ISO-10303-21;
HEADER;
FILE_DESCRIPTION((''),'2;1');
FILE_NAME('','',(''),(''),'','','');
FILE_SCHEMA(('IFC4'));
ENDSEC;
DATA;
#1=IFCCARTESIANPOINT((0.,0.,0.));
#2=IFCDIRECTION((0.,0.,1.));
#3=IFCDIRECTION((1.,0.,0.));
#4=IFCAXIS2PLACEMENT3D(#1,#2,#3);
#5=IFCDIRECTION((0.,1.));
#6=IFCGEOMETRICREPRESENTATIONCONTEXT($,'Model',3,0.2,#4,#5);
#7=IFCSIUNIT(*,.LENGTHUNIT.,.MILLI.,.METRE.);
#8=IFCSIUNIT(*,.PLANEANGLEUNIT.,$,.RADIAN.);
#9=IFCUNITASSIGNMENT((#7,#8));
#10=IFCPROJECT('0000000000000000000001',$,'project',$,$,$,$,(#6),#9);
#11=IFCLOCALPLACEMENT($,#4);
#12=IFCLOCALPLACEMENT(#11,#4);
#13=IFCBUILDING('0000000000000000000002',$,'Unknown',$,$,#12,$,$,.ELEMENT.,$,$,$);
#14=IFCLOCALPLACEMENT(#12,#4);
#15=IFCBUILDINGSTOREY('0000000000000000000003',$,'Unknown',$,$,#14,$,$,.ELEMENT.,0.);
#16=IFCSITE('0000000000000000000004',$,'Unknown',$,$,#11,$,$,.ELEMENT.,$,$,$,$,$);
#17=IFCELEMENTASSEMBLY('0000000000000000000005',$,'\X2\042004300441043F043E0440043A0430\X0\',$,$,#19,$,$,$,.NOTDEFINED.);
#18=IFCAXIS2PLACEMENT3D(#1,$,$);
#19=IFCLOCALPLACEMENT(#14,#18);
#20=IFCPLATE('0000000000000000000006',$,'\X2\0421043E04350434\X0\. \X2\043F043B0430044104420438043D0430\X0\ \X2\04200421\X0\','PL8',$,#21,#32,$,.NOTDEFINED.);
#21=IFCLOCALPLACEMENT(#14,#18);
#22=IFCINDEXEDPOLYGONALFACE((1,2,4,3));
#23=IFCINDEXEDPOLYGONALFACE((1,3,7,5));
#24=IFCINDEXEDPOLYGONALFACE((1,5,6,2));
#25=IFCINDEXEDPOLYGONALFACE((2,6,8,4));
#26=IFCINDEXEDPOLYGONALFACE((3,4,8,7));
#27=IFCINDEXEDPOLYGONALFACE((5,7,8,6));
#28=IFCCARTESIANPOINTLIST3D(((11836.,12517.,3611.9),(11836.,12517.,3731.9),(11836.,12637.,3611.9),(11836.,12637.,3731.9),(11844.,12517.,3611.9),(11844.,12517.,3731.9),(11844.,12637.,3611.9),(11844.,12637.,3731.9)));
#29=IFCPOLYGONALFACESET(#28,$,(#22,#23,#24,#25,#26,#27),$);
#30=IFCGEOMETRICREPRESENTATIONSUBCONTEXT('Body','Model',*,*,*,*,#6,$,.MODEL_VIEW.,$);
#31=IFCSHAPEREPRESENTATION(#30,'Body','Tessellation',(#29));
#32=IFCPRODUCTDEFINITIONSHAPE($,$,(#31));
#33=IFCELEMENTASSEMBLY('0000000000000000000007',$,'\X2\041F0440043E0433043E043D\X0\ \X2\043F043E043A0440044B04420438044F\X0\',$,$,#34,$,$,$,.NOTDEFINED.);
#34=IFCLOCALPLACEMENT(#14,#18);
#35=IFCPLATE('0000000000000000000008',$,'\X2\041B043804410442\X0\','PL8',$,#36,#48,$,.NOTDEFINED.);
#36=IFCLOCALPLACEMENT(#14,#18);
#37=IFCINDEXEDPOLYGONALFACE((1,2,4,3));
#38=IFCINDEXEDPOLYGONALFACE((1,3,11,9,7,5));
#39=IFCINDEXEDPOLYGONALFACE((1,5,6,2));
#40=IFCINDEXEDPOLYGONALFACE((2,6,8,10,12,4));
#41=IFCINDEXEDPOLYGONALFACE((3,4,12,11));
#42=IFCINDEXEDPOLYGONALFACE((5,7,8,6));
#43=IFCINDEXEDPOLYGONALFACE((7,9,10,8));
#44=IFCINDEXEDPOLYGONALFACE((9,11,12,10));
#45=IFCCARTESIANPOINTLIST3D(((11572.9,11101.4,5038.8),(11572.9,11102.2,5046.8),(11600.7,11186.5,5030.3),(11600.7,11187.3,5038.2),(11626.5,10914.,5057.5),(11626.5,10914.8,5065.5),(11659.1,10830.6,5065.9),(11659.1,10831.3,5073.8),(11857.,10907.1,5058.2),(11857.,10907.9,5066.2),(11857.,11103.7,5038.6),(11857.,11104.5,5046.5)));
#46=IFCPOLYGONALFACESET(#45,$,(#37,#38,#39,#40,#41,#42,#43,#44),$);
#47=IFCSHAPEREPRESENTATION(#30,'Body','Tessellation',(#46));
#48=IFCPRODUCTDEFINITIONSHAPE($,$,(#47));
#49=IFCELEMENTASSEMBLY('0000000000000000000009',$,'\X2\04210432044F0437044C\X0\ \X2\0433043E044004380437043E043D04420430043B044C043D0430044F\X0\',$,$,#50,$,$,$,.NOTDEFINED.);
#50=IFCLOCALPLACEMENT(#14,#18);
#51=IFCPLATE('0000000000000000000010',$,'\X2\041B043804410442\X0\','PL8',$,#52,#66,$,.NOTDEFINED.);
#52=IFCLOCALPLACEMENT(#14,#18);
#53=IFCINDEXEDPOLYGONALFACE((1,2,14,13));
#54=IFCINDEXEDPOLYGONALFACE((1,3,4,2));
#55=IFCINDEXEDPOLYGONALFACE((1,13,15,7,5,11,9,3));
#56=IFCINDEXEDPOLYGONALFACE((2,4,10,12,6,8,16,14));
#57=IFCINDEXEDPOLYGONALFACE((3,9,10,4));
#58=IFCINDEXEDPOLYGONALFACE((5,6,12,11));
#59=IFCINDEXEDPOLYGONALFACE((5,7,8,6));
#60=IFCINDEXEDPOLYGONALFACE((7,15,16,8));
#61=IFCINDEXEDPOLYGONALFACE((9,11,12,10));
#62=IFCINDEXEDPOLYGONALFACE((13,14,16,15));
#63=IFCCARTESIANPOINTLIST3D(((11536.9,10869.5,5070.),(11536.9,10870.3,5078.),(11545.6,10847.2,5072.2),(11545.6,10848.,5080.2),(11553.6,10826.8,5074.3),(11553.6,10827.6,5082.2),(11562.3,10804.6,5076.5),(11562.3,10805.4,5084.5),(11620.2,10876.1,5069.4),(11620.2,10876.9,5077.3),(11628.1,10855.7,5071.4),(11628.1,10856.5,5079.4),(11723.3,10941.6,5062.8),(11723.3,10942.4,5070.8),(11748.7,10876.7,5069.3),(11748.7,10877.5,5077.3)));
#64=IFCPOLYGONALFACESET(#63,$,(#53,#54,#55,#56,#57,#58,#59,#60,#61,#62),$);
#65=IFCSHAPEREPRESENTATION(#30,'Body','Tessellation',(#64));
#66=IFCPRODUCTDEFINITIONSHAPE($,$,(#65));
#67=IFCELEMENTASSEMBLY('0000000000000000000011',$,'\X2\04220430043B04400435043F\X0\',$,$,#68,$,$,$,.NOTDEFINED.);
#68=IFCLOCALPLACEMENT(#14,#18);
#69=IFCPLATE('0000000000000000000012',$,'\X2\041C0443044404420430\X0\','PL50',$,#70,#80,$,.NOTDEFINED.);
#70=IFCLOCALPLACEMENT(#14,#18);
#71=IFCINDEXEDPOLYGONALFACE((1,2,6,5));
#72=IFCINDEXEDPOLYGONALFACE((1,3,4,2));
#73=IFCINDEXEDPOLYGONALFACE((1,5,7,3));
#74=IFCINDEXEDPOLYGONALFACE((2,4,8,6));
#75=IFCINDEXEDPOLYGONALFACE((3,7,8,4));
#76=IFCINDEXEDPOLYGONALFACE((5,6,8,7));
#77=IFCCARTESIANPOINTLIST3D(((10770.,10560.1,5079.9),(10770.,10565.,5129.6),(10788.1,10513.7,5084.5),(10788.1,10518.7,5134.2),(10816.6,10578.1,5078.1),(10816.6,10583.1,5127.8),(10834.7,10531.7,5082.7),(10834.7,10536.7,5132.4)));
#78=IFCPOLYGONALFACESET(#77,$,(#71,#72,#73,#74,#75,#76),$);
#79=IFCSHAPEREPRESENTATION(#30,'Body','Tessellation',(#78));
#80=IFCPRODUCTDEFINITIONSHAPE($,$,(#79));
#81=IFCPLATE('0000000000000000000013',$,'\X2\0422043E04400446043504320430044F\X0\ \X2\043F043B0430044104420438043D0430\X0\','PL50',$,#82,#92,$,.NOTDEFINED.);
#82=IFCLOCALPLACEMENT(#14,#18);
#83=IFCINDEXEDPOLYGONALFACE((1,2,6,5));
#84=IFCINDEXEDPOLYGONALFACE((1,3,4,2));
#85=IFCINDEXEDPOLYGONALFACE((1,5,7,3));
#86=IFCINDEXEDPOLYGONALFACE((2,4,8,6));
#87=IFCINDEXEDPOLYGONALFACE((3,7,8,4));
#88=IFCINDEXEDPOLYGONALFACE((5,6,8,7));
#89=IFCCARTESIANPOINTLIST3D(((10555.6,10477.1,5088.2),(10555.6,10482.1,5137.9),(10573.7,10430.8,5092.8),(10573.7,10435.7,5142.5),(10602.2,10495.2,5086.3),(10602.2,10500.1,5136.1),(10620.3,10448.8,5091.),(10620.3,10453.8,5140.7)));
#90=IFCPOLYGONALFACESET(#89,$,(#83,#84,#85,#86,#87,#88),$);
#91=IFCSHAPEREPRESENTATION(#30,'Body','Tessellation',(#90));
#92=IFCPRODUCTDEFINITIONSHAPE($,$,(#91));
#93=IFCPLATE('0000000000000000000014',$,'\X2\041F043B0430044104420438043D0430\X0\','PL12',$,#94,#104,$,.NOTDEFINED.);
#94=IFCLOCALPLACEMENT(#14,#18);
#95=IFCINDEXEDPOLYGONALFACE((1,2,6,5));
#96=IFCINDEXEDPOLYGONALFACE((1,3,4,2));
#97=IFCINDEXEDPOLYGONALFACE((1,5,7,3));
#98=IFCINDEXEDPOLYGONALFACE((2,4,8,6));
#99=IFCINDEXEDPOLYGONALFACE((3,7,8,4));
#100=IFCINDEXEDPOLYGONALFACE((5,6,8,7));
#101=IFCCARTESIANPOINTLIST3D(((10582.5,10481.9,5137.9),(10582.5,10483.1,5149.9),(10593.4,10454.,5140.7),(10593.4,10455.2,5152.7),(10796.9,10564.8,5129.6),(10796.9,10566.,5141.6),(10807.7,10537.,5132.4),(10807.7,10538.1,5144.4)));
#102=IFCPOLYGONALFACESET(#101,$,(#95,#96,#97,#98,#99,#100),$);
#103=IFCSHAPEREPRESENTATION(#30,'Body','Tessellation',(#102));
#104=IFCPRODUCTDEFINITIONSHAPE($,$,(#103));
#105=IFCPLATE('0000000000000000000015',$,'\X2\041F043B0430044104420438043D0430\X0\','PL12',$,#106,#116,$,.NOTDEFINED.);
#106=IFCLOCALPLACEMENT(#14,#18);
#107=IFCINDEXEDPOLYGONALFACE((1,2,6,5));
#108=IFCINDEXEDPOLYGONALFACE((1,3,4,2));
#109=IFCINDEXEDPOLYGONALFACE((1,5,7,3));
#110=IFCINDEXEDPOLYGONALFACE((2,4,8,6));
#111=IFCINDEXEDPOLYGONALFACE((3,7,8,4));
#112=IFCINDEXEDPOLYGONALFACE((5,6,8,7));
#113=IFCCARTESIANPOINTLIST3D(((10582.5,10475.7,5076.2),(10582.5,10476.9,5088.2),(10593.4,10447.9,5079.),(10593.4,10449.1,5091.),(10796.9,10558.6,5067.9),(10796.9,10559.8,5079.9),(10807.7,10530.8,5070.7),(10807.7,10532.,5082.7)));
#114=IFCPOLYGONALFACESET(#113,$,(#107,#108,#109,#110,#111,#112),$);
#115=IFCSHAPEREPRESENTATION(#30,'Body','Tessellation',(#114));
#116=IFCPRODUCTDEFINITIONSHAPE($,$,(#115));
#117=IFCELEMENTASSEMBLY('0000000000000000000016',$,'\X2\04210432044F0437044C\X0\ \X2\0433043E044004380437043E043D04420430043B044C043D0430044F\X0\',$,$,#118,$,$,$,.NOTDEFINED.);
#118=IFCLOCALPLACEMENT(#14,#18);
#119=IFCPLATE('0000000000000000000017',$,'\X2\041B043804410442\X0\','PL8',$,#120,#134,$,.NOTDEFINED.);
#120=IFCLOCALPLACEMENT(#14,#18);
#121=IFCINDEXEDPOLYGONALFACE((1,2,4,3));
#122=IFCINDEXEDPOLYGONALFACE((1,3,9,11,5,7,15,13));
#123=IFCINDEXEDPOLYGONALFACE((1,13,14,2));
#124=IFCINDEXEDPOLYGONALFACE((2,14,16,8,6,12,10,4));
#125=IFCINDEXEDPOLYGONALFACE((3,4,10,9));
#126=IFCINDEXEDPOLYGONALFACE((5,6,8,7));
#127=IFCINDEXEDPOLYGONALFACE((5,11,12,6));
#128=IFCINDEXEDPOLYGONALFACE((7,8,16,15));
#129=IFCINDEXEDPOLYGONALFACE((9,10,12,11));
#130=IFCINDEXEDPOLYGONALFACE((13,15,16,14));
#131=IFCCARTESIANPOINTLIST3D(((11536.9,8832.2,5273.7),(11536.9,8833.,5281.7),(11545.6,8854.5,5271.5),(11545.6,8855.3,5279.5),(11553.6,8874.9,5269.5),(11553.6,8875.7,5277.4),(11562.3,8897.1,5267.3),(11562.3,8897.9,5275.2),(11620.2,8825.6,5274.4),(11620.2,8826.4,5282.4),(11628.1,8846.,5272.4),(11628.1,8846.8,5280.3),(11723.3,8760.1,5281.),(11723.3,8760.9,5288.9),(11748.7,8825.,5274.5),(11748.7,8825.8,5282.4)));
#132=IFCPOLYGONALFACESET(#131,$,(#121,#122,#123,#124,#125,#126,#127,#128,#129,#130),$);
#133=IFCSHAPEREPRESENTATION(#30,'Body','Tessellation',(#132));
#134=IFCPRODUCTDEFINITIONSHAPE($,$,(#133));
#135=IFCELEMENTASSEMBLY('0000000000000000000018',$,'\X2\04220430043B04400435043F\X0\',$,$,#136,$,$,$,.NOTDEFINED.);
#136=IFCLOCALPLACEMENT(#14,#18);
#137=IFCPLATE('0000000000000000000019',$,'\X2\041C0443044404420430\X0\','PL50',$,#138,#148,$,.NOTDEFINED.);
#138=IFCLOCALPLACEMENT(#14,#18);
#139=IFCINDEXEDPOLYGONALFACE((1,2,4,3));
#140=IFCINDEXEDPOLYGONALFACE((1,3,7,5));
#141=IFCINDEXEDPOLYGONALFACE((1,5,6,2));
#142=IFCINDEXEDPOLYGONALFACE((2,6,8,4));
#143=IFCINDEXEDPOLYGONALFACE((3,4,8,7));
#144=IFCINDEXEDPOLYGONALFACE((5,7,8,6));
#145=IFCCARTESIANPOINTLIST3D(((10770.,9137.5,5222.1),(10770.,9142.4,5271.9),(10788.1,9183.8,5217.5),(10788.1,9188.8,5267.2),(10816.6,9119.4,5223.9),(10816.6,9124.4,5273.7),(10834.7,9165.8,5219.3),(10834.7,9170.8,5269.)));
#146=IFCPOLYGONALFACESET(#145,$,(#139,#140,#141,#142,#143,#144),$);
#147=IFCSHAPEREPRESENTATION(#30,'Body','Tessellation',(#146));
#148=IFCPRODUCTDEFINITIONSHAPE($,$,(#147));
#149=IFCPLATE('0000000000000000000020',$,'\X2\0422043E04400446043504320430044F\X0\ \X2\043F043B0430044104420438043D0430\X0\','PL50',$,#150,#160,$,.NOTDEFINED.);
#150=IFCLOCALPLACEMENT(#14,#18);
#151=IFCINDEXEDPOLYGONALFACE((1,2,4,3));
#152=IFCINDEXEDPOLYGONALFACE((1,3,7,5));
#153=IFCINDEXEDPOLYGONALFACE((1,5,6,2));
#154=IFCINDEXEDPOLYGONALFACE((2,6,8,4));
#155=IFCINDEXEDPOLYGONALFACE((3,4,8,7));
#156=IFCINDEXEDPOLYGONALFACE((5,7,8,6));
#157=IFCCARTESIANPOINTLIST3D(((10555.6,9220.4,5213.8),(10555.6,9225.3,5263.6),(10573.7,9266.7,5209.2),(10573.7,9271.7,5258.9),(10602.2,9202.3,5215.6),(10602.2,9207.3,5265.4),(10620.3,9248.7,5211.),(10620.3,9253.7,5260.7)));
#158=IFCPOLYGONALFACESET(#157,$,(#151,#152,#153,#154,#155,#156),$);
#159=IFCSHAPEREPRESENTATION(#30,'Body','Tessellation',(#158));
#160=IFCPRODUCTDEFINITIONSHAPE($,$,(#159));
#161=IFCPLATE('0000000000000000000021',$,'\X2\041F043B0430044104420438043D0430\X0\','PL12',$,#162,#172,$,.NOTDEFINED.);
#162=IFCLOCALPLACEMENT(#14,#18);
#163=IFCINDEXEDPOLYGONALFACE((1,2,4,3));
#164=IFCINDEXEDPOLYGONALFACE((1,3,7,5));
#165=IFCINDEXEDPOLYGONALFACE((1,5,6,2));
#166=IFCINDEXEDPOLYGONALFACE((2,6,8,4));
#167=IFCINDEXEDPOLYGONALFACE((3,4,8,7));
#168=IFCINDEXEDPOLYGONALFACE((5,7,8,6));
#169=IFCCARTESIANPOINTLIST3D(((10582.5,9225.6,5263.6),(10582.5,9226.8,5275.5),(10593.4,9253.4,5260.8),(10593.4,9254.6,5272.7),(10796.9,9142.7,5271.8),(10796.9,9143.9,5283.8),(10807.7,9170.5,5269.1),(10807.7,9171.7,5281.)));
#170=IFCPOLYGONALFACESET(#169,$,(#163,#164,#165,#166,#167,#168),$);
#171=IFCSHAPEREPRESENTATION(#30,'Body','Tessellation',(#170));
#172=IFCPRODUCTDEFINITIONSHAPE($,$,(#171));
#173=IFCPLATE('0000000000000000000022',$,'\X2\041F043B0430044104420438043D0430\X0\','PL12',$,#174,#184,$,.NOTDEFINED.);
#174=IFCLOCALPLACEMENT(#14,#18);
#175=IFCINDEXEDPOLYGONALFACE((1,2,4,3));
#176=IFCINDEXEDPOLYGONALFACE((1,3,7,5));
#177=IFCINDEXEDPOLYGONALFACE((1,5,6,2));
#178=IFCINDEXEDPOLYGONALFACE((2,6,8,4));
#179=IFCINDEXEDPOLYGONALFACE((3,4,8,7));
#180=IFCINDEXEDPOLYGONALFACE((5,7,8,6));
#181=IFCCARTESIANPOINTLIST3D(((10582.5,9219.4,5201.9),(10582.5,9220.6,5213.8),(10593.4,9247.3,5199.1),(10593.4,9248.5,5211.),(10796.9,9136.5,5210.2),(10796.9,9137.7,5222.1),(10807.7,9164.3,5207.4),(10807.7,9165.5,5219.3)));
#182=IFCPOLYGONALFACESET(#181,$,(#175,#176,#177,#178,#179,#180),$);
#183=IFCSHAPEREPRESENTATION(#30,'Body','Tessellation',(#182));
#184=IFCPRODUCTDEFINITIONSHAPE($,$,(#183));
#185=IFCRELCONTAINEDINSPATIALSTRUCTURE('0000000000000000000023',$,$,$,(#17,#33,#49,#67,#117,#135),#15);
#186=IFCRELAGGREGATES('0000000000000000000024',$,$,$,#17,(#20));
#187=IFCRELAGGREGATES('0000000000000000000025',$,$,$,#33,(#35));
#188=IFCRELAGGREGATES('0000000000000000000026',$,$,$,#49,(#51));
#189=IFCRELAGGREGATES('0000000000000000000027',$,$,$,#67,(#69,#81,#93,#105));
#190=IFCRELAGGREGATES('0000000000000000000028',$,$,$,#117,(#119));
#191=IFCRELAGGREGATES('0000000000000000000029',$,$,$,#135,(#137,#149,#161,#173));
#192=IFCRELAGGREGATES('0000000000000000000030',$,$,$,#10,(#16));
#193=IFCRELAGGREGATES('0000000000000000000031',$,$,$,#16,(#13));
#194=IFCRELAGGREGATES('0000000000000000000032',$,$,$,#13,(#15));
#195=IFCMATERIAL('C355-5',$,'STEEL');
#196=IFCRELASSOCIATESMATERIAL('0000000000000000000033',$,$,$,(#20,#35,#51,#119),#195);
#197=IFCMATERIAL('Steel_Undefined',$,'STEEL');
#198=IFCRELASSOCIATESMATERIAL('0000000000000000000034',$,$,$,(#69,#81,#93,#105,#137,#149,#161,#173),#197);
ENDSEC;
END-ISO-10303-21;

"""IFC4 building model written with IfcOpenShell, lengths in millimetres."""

from ifc_helpers import new_model, si_unit, direction, frame, origin_with_axes, place, context, subcontext, project, spatial, line, indexed_curve, outline, extrude, material, element, aggregate, save


model = new_model("IFC4")

# Units and contexts
model_context = context("Model", 3, precision=0.2, world=origin_with_axes(), true_north=direction((0.0, 1.0)))
body_context = subcontext(model_context, "Body", "Model", "MODEL_VIEW")
ifc_project = project(units=[si_unit("LENGTHUNIT", "METRE", prefix="MILLI"), si_unit("PLANEANGLEUNIT", "RADIAN")], contexts=[model_context])

# Site, building, storey
site_placement = place(None, origin_with_axes())
site = spatial("IfcSite", under=ifc_project, at=site_placement, Name="Unknown", CompositionType="ELEMENT")
building_placement = place(site_placement, origin_with_axes())
building = spatial("IfcBuilding", under=site, at=building_placement, Name="Unknown", CompositionType="ELEMENT")
storey_placement = place(building_placement, origin_with_axes())
storey = spatial("IfcBuildingStorey", under=building, at=storey_placement, Name="Unknown", CompositionType="ELEMENT", Elevation=0.0)

# Element assemblies, plates
assembly_1_placement = place(storey_placement, frame((6000.0, 12577.0, 3671.9), z_axis=(0.0, -1.0, 0.0), x_axis=(1.0, 0.0, 0.0)))
assembly_1 = element("IfcElementAssembly", 1, at=assembly_1_placement, inside=storey, Name="Распорка", PredefinedType="NOTDEFINED")
ifc_material_1 = material(Name="C355-5", Category="STEEL")
plate_1_placement = place(assembly_1_placement, frame((5840.0, 60.0, -60.0), z_axis=(1.0, 0.0, 0.0), x_axis=(0.0, 0.0, 1.0)))
plate_1 = element("IfcPlate", 2, at=plate_1_placement, material=ifc_material_1, Name="Соед. пластина РС", Description="PL8", PredefinedType="NOTDEFINED", context=body_context, shape_type="SolidModel", body=[
    extrude(outline(indexed_curve([(0.0, 0.0), (120.0, 0.0), (120.0, 120.0), (0.0, 120.0)], segments=[line(1, 2, 3, 4, 1)])), frame((0.0, 0.0, 4.0), z_axis=(0.0, 0.0, 1.0), x_axis=(1.0, 0.0, 0.0)), (0.0, 0.0, -1.0), 8.0),
])
aggregate(assembly_1, [plate_1])
assembly_2_placement = place(storey_placement, frame((12000.0, 11010.8, 5051.9), z_axis=(0.0, -0.995037, 0.099504), x_axis=(-1.0, 0.0, 0.0)))
assembly_2 = element("IfcElementAssembly", 3, at=assembly_2_placement, inside=storey, Name="Прогон покрытия", PredefinedType="NOTDEFINED")
plate_2_placement = place(assembly_2_placement, frame((373.5, 0.0, 96.9), z_axis=(0.0, -1.0, 0.0), x_axis=(-0.362317, 0.0, 0.932055)))
plate_2 = element("IfcPlate", 4, at=plate_2_placement, material=ifc_material_1, Name="Лист", Description="PL8", PredefinedType="NOTDEFINED", context=body_context, shape_type="SolidModel", body=[
    extrude(outline(indexed_curve([(0.0, 0.0), (90.0, 0.0), (90.0, 212.3), (-94.2, 283.9), (-264.6, 75.2), (-194.9, 18.3)], segments=[line(1, 2, 3, 4, 5, 6, 1)])), frame((0.0, 0.0, 4.0), z_axis=(0.0, 0.0, 1.0), x_axis=(1.0, 0.0, 0.0)), (0.0, 0.0, -1.0), 8.0),
])
aggregate(assembly_2, [plate_2])
assembly_3_placement = place(storey_placement, frame((10695.1, 10506.9, 5110.3), z_axis=(0.362317, -0.927429, 0.092743), x_axis=(0.932055, 0.360519, -0.036052)))
assembly_3 = element("IfcElementAssembly", 5, at=assembly_3_placement, inside=storey, Name="Связь горизонтальная", PredefinedType="NOTDEFINED")
plate_3_placement = place(assembly_3_placement, frame((916.8, 0.0, -35.0), z_axis=(0.0, -1.0, 0.0), x_axis=(1.0, 0.0, 0.0)))
plate_3 = element("IfcPlate", 6, at=plate_3_placement, material=ifc_material_1, Name="Лист", Description="PL8", PredefinedType="NOTDEFINED", context=body_context, shape_type="SolidModel", body=[
    extrude(outline(indexed_curve([(0.0, 0.0), (200.0, 0.0), (200.0, 70.0), (0.0, 70.0), (0.0, 46.0), (80.0, 46.0), (80.0, 24.0), (0.0, 24.0)], segments=[line(1, 2, 3, 4, 5, 6, 7, 8, 1)])), frame((0.0, 0.0, 4.0), z_axis=(0.0, 0.0, 1.0), x_axis=(1.0, 0.0, 0.0)), (0.0, 0.0, -1.0), 8.0),
])
aggregate(assembly_3, [plate_3])

# Element assembly, plates
assembly_4_placement = place(storey_placement, frame((10811.4, 10527.7, 5133.3), z_axis=(-0.932055, -0.360519, 0.036052), x_axis=(-0.362317, 0.927429, -0.092743)))
assembly_4 = element("IfcElementAssembly", 7, at=assembly_4_placement, inside=storey, Name="Талреп", PredefinedType="NOTDEFINED")
ifc_material_2 = material(Name="Steel_Undefined", Category="STEEL")
plate_4_placement = place(assembly_4_placement, origin_with_axes())
plate_4 = element("IfcPlate", 8, at=plate_4_placement, material=ifc_material_2, Name="Муфта", Description="PL50", PredefinedType="NOTDEFINED", context=body_context, shape_type="SolidModel", body=[
    extrude(outline(indexed_curve([(0.0, 0.0), (50.0, 0.0), (50.0, 50.0), (0.0, 50.0)], segments=[line(1, 2, 3, 4, 1)])), frame((0.0, 0.0, 25.0), z_axis=(0.0, 0.0, 1.0), x_axis=(1.0, 0.0, 0.0)), (0.0, 0.0, -1.0), 50.0),
])
plate_5_placement = place(assembly_4_placement, frame((0.0, 0.0, 230.0), z_axis=(0.0, 0.0, 1.0), x_axis=(1.0, 0.0, 0.0)))
plate_5 = element("IfcPlate", 9, at=plate_5_placement, material=ifc_material_2, Name="Торцевая пластина", Description="PL50", PredefinedType="NOTDEFINED", context=body_context, shape_type="SolidModel", body=[
    extrude(outline(indexed_curve([(0.0, 0.0), (50.0, 0.0), (50.0, 50.0), (0.0, 50.0)], segments=[line(1, 2, 3, 4, 1)])), frame((0.0, 0.0, 25.0), z_axis=(0.0, 0.0, 1.0), x_axis=(1.0, 0.0, 0.0)), (0.0, 0.0, -1.0), 50.0),
])
plate_6_placement = place(assembly_4_placement, frame((10.0, -6.0, 230.0), z_axis=(0.0, 1.0, 0.0), x_axis=(1.0, 0.0, 0.0)))
plate_6 = element("IfcPlate", 10, at=plate_6_placement, material=ifc_material_2, Name="Пластина", Description="PL12", PredefinedType="NOTDEFINED", context=body_context, shape_type="SolidModel", body=[
    extrude(outline(indexed_curve([(0.0, 0.0), (30.0, 0.0), (30.0, 230.0), (0.0, 230.0)], segments=[line(1, 2, 3, 4, 1)])), frame((0.0, 0.0, 6.0), z_axis=(0.0, 0.0, 1.0), x_axis=(1.0, 0.0, 0.0)), (0.0, 0.0, -1.0), 12.0),
])
plate_7_placement = place(assembly_4_placement, frame((10.0, 56.0, 230.0), z_axis=(0.0, 1.0, 0.0), x_axis=(1.0, 0.0, 0.0)))
plate_7 = element("IfcPlate", 11, at=plate_7_placement, material=ifc_material_2, Name="Пластина", Description="PL12", PredefinedType="NOTDEFINED", context=body_context, shape_type="SolidModel", body=[
    extrude(outline(indexed_curve([(0.0, 0.0), (30.0, 0.0), (30.0, 230.0), (0.0, 230.0)], segments=[line(1, 2, 3, 4, 1)])), frame((0.0, 0.0, 6.0), z_axis=(0.0, 0.0, 1.0), x_axis=(1.0, 0.0, 0.0)), (0.0, 0.0, -1.0), 12.0),
])
aggregate(assembly_4, [plate_4, plate_5, plate_6, plate_7])

# Element assembly, plate
assembly_5_placement = place(storey_placement, frame((10695.1, 9195.6, 5241.4), z_axis=(-0.362317, -0.927429, 0.092743), x_axis=(0.932055, -0.360519, 0.036052)))
assembly_5 = element("IfcElementAssembly", 12, at=assembly_5_placement, inside=storey, Name="Связь горизонтальная", PredefinedType="NOTDEFINED")
plate_8_placement = place(assembly_5_placement, frame((916.8, 0.0, -35.0), z_axis=(0.0, -1.0, 0.0), x_axis=(1.0, 0.0, 0.0)))
plate_8 = element("IfcPlate", 13, at=plate_8_placement, material=ifc_material_1, Name="Лист", Description="PL8", PredefinedType="NOTDEFINED", context=body_context, shape_type="SolidModel", body=[
    extrude(outline(indexed_curve([(0.0, 0.0), (200.0, 0.0), (200.0, 70.0), (0.0, 70.0), (0.0, 46.0), (80.0, 46.0), (80.0, 24.0), (0.0, 24.0)], segments=[line(1, 2, 3, 4, 5, 6, 7, 8, 1)])), frame((0.0, 0.0, 4.0), z_axis=(0.0, 0.0, 1.0), x_axis=(1.0, 0.0, 0.0)), (0.0, 0.0, -1.0), 8.0),
])
aggregate(assembly_5, [plate_8])

# Element assembly, plates
assembly_6_placement = place(storey_placement, frame((10793.3, 9133.4, 5272.8), z_axis=(-0.932055, 0.360519, -0.036052), x_axis=(0.362317, 0.927429, -0.092743)))
assembly_6 = element("IfcElementAssembly", 14, at=assembly_6_placement, inside=storey, Name="Талреп", PredefinedType="NOTDEFINED")
plate_9_placement = place(assembly_6_placement, origin_with_axes())
plate_9 = element("IfcPlate", 15, at=plate_9_placement, material=ifc_material_2, Name="Муфта", Description="PL50", PredefinedType="NOTDEFINED", context=body_context, shape_type="SolidModel", body=[
    extrude(outline(indexed_curve([(0.0, 0.0), (50.0, 0.0), (50.0, 50.0), (0.0, 50.0)], segments=[line(1, 2, 3, 4, 1)])), frame((0.0, 0.0, 25.0), z_axis=(0.0, 0.0, 1.0), x_axis=(1.0, 0.0, 0.0)), (0.0, 0.0, -1.0), 50.0),
])
plate_10_placement = place(assembly_6_placement, frame((0.0, 0.0, 230.0), z_axis=(0.0, 0.0, 1.0), x_axis=(1.0, 0.0, 0.0)))
plate_10 = element("IfcPlate", 16, at=plate_10_placement, material=ifc_material_2, Name="Торцевая пластина", Description="PL50", PredefinedType="NOTDEFINED", context=body_context, shape_type="SolidModel", body=[
    extrude(outline(indexed_curve([(0.0, 0.0), (50.0, 0.0), (50.0, 50.0), (0.0, 50.0)], segments=[line(1, 2, 3, 4, 1)])), frame((0.0, 0.0, 25.0), z_axis=(0.0, 0.0, 1.0), x_axis=(1.0, 0.0, 0.0)), (0.0, 0.0, -1.0), 50.0),
])
plate_11_placement = place(assembly_6_placement, frame((10.0, -6.0, 230.0), z_axis=(0.0, 1.0, 0.0), x_axis=(1.0, 0.0, 0.0)))
plate_11 = element("IfcPlate", 17, at=plate_11_placement, material=ifc_material_2, Name="Пластина", Description="PL12", PredefinedType="NOTDEFINED", context=body_context, shape_type="SolidModel", body=[
    extrude(outline(indexed_curve([(0.0, 0.0), (30.0, 0.0), (30.0, 230.0), (0.0, 230.0)], segments=[line(1, 2, 3, 4, 1)])), frame((0.0, 0.0, 6.0), z_axis=(0.0, 0.0, 1.0), x_axis=(1.0, 0.0, 0.0)), (0.0, 0.0, -1.0), 12.0),
])
plate_12_placement = place(assembly_6_placement, frame((10.0, 56.0, 230.0), z_axis=(0.0, 1.0, 0.0), x_axis=(1.0, 0.0, 0.0)))
plate_12 = element("IfcPlate", 18, at=plate_12_placement, material=ifc_material_2, Name="Пластина", Description="PL12", PredefinedType="NOTDEFINED", context=body_context, shape_type="SolidModel", body=[
    extrude(outline(indexed_curve([(0.0, 0.0), (30.0, 0.0), (30.0, 230.0), (0.0, 230.0)], segments=[line(1, 2, 3, 4, 1)])), frame((0.0, 0.0, 6.0), z_axis=(0.0, 0.0, 1.0), x_axis=(1.0, 0.0, 0.0)), (0.0, 0.0, -1.0), 12.0),
])
aggregate(assembly_6, [plate_9, plate_10, plate_11, plate_12])

save(model, "model.ifc")
